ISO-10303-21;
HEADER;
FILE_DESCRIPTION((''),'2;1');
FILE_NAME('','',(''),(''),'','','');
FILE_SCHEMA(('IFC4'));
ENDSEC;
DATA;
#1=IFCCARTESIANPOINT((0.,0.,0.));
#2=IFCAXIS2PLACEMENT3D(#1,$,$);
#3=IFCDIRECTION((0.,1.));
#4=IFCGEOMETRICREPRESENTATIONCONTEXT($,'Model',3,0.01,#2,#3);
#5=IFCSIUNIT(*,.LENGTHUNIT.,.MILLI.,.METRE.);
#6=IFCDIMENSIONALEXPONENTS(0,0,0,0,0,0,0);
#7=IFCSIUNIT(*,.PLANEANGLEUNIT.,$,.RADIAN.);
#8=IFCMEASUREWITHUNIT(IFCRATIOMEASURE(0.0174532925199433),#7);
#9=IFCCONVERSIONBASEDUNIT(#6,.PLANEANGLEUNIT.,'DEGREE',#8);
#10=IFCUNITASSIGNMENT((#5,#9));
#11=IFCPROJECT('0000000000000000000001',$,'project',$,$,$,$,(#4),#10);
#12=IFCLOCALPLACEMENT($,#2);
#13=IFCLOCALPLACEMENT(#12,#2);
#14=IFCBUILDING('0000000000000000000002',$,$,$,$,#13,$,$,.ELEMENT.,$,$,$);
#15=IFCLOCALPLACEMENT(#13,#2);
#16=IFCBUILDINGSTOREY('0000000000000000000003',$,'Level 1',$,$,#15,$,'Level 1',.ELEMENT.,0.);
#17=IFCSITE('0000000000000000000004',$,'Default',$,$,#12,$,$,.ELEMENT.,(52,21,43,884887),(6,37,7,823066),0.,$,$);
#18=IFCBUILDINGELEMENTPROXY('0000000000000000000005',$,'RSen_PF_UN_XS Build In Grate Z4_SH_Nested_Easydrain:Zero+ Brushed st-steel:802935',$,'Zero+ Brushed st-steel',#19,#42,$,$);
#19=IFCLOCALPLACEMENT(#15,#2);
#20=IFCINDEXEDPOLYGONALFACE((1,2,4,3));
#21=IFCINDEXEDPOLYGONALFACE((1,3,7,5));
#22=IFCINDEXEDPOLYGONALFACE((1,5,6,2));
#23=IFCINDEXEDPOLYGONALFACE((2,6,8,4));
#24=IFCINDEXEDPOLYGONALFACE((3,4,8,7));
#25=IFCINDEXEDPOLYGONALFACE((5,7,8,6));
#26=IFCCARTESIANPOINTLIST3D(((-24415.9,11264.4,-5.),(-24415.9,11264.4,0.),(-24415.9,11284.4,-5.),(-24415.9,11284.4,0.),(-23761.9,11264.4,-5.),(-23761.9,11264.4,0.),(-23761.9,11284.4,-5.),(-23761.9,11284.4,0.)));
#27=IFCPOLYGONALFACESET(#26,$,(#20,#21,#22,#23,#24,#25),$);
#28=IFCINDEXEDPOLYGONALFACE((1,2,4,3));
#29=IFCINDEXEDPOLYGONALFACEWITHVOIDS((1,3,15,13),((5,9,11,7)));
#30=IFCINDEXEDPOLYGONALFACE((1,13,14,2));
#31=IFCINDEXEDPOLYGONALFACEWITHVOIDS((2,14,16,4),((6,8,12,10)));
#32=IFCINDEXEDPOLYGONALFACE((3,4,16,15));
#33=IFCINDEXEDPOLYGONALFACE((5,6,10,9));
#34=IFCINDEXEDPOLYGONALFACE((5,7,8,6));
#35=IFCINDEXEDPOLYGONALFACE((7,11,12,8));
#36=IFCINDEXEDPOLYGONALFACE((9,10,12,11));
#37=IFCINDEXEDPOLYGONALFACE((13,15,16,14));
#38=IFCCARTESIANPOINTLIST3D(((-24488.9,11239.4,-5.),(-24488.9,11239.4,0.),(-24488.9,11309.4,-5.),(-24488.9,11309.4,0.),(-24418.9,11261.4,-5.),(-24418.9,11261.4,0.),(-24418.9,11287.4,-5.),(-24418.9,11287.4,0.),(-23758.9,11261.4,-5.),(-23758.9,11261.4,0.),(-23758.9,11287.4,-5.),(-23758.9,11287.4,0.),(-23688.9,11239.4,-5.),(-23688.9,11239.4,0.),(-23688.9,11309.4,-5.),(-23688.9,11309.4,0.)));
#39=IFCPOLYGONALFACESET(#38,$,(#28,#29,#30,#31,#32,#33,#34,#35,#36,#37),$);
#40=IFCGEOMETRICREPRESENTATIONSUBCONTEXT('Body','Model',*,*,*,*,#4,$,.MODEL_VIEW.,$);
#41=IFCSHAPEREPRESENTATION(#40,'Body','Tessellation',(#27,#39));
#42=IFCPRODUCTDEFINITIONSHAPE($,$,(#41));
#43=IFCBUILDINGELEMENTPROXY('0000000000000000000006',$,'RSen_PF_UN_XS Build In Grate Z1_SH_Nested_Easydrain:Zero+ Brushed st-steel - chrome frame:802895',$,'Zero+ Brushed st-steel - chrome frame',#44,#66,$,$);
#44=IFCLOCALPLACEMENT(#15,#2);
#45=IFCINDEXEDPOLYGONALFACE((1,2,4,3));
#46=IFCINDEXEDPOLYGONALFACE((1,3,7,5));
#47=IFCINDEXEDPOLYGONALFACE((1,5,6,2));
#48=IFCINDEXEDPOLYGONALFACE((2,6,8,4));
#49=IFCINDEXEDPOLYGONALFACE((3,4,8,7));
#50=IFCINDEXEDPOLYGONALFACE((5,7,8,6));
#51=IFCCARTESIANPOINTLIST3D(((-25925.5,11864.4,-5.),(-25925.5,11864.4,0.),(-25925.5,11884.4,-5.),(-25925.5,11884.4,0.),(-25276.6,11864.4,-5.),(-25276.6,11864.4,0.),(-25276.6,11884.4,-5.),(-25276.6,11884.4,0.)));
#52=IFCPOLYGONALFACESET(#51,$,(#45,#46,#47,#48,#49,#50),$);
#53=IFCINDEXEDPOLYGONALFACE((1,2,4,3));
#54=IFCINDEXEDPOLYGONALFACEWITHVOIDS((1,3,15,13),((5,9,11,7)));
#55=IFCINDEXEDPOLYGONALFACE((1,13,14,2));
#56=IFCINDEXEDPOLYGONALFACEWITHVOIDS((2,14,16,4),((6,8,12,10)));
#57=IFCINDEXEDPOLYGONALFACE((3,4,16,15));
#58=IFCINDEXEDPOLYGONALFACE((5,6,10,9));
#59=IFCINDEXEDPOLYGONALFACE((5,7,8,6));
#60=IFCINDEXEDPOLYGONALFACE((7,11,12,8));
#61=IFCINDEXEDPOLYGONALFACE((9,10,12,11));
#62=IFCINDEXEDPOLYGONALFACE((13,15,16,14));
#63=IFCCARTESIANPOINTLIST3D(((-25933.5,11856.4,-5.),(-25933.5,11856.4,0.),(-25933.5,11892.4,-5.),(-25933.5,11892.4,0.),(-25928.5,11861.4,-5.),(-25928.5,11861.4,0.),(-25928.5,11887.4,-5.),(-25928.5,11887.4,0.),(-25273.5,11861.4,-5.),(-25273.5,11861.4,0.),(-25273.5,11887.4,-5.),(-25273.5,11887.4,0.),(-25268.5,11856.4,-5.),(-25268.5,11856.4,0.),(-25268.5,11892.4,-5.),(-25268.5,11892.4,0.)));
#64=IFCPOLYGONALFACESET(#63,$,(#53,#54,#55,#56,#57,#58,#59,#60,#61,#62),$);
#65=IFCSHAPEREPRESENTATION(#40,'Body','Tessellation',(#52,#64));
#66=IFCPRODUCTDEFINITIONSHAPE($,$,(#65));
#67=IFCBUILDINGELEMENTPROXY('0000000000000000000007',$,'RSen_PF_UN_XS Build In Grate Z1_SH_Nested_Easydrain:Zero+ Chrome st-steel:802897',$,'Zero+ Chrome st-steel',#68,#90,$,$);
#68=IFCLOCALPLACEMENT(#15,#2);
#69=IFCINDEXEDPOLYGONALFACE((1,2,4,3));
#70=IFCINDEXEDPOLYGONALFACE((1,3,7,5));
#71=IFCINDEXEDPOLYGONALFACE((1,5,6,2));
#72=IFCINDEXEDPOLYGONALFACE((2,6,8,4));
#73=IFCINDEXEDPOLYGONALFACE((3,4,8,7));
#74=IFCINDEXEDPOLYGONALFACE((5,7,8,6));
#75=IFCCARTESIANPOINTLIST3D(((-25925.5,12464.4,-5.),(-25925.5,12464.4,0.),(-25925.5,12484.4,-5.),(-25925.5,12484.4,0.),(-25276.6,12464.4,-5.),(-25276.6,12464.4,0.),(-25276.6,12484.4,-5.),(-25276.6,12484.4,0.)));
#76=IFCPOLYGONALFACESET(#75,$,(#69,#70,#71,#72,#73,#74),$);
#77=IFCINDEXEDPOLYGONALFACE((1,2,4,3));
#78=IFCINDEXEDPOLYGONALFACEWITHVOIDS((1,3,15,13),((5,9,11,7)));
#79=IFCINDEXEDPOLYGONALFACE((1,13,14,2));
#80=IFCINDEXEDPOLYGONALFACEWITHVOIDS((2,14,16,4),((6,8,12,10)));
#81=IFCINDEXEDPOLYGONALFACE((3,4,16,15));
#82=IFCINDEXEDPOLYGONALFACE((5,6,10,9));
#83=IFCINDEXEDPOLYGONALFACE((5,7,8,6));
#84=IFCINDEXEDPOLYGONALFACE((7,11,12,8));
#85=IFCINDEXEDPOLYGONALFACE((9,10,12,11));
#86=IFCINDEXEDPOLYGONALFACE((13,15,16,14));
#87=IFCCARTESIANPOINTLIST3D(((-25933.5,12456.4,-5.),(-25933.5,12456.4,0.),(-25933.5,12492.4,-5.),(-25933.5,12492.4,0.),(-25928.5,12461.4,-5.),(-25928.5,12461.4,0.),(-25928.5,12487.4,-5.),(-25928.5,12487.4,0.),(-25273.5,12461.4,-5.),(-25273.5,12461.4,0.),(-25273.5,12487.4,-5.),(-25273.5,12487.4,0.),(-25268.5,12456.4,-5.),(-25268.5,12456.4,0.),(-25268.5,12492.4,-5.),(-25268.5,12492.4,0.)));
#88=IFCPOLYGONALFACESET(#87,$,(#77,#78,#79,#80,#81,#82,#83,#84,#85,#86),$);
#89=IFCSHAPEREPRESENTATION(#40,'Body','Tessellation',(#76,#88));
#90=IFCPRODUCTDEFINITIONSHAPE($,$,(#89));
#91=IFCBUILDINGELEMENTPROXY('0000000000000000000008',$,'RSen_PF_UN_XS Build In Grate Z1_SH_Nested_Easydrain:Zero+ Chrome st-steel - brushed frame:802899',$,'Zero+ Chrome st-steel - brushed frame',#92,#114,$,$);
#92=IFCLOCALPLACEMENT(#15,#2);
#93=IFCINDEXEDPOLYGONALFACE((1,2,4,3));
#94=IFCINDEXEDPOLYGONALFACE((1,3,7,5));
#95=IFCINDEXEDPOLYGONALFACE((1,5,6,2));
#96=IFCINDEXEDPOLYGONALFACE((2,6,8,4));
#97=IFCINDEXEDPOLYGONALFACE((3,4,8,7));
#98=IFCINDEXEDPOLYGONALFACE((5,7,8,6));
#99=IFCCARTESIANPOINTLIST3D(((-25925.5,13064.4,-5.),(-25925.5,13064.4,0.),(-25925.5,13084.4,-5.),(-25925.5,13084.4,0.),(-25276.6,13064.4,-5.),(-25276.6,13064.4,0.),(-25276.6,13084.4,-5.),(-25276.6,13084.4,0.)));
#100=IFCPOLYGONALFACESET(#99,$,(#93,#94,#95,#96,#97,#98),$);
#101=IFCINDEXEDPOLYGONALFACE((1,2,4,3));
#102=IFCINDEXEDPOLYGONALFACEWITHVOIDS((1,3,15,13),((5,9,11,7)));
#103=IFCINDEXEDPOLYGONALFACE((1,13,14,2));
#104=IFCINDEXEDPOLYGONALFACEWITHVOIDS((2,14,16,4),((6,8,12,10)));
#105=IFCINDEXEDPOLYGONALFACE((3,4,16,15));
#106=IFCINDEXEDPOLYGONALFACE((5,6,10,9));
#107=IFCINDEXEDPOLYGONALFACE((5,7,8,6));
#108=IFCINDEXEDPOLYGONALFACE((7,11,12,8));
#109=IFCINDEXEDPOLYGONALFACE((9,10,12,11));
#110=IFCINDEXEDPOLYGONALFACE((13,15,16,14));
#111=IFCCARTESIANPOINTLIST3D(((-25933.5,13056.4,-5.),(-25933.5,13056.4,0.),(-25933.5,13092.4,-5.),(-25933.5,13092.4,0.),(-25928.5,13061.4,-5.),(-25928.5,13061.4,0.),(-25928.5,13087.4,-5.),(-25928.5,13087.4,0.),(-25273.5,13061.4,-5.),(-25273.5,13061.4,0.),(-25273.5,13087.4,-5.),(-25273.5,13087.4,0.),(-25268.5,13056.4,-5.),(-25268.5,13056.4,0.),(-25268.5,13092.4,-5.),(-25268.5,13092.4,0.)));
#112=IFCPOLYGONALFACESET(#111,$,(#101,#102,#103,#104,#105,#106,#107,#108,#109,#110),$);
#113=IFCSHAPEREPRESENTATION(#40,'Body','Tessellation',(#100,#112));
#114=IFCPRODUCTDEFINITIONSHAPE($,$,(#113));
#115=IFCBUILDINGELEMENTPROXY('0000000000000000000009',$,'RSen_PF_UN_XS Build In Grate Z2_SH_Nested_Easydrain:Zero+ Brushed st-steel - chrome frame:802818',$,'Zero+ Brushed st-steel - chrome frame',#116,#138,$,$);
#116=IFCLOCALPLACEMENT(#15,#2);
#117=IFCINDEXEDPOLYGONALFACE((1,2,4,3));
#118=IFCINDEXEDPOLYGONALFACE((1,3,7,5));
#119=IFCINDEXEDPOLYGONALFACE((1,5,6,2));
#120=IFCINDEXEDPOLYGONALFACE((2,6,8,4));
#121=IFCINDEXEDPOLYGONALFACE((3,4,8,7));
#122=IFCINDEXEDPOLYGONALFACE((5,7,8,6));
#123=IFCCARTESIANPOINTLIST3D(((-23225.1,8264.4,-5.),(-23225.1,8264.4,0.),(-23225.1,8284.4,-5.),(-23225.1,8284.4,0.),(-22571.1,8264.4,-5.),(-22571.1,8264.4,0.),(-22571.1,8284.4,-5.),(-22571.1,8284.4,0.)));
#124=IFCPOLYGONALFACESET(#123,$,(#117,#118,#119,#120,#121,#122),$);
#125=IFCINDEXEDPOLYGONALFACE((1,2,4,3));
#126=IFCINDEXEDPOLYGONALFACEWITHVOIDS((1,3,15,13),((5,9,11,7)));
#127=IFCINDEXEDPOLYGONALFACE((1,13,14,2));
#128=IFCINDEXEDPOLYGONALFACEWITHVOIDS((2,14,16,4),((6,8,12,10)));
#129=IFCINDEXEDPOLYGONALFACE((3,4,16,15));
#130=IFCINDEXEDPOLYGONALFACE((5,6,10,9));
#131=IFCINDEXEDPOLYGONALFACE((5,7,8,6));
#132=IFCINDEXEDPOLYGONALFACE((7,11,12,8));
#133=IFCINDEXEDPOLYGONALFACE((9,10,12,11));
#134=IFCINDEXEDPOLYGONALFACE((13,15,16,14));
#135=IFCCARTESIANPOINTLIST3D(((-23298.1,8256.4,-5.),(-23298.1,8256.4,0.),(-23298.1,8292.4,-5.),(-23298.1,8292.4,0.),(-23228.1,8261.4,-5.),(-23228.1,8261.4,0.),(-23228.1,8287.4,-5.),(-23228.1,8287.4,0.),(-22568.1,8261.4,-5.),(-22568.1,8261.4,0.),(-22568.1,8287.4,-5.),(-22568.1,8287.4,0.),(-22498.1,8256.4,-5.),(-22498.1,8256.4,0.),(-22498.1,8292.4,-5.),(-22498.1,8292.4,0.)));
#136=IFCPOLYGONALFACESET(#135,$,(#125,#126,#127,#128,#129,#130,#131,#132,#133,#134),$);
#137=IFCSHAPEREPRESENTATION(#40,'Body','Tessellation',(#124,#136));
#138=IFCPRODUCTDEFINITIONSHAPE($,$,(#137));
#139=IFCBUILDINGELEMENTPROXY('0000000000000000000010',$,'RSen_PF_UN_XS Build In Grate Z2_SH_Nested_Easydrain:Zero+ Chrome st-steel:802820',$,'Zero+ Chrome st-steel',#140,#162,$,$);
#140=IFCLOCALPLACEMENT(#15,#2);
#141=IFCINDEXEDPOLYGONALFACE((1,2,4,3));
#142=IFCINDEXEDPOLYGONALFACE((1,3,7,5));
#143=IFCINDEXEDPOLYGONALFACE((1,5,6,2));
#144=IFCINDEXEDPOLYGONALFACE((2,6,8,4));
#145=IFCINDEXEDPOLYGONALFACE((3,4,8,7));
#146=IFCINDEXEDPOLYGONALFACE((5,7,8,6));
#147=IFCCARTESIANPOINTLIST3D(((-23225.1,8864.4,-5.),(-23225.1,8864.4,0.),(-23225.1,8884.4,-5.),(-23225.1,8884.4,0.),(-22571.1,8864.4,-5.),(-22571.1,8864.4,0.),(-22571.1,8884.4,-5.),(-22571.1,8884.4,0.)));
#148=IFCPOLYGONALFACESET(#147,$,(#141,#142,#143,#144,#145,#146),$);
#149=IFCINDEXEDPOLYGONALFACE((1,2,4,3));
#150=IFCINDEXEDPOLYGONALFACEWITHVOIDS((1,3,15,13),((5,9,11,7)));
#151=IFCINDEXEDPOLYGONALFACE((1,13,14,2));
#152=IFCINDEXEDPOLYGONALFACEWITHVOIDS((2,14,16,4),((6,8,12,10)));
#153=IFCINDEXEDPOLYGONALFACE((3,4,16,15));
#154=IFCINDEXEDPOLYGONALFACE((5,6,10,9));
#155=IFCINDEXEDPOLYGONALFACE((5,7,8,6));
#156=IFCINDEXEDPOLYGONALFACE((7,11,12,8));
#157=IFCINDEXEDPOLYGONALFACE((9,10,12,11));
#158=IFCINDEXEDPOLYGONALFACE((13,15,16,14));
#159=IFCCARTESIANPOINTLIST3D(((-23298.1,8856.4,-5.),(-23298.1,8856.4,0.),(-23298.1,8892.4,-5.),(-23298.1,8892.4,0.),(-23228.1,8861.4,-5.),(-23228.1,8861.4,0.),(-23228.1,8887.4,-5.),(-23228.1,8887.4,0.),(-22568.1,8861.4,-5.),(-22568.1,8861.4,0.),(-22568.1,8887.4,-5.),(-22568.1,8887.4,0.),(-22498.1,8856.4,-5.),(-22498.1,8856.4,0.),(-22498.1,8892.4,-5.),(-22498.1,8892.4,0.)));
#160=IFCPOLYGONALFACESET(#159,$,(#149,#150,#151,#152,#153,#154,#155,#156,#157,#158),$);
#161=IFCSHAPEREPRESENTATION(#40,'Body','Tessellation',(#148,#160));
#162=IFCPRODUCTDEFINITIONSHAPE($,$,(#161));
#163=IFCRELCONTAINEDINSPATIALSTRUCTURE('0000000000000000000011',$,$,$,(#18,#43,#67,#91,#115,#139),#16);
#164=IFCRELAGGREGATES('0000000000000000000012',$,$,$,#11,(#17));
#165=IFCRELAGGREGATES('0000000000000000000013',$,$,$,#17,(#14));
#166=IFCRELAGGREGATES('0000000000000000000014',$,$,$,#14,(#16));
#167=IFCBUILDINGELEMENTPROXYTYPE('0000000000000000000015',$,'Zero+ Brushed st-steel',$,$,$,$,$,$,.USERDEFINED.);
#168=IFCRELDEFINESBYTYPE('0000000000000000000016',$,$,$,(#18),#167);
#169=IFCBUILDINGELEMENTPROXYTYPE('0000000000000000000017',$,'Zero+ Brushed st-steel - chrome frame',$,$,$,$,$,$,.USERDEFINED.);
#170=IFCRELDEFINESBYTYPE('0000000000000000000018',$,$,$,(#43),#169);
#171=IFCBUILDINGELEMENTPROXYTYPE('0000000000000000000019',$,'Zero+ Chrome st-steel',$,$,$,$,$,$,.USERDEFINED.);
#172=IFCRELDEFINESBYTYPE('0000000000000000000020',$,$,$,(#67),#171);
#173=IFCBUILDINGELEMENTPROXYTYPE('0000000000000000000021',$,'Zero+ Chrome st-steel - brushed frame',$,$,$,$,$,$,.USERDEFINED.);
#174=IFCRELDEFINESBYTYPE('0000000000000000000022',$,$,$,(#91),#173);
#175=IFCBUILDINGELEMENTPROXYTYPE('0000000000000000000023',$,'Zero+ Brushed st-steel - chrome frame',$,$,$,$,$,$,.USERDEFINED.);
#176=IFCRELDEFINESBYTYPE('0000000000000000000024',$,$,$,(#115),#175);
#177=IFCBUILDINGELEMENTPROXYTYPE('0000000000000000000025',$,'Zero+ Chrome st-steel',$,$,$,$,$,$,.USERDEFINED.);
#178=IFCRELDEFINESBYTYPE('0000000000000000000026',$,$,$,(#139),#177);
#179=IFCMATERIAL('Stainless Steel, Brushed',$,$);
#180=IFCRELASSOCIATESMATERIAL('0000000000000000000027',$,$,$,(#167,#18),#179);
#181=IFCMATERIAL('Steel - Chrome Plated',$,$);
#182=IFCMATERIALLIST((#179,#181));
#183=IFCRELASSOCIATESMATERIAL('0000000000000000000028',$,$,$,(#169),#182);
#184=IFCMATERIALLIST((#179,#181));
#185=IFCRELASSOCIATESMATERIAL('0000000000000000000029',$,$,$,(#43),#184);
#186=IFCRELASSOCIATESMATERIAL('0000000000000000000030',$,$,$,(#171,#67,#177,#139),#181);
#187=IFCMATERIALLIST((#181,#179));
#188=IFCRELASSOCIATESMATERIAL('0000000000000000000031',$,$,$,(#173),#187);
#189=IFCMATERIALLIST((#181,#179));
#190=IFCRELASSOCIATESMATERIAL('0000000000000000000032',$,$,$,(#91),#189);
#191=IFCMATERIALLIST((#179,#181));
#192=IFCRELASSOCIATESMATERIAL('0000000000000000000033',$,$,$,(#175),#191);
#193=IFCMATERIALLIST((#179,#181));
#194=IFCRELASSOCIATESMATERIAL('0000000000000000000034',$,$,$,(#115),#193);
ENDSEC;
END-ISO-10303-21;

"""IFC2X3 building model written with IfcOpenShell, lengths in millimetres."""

from ifc_helpers import new_model, entity, si_unit, converted_unit, direction, frame, origin, origin_2d_with_axis, place, context, subcontext, project, spatial, polyline, rectangle, outline, extrude, source, transform, mapped, material, material_list, type_object, type_shapes, element, save


model = new_model("IFC2X3")

# Units and contexts
model_context = context("Model", 3, precision=0.01, world=origin(), true_north=direction((0.0, 1.0)))
body_context = subcontext(model_context, "Body", "Model", "MODEL_VIEW")
ifc_project = project(units=[si_unit("LENGTHUNIT", "METRE", prefix="MILLI"), converted_unit("PLANEANGLEUNIT", "DEGREE", entity("IfcRatioMeasure", 0.0174532925199433), si_unit("PLANEANGLEUNIT", "RADIAN"), dimensions=[0, 0, 0, 0, 0, 0, 0])], contexts=[model_context])

# Site, building, storey
site_placement = place(None, origin())
site = spatial("IfcSite", under=ifc_project, at=site_placement, Name="Default", CompositionType="ELEMENT", RefLatitude=(52, 21, 43, 884887), RefLongitude=(6, 37, 7, 823066), RefElevation=0.0)
building_placement = place(site_placement, origin())
building = spatial("IfcBuilding", under=site, at=building_placement, CompositionType="ELEMENT")
storey_placement = place(building_placement, origin())
storey = spatial("IfcBuildingStorey", under=building, at=storey_placement, Name="Level 1", LongName="Level 1", CompositionType="ELEMENT", Elevation=0.0)

# Shared definitions
ifc_material_1 = material(Name="Stainless Steel, Brushed")

# Building element proxies
building_element_proxy_type_1 = type_object("IfcBuildingElementProxyType", Name="Zero+ Brushed st-steel", PredefinedType="USERDEFINED", material=ifc_material_1)
shared_shape_1 = source(origin(), body_context, "Body", "SweptSolid", [
    extrude(rectangle(XDim=654.0, YDim=20.0, at=origin_2d_with_axis()), frame((0.0, 0.0, 0.0), z_axis=(0.0, 0.0, 1.0), x_axis=(-1.0, 0.0, 0.0)), (0.0, 0.0, 1.0), 5.0),
    extrude(outline(polyline([(-400.0, -35.0), (400.0, -35.0), (400.0, 35.0), (-400.0, 35.0), (-400.0, -35.0)]), holes=[polyline([(-330.0, -13.0), (-330.0, 13.0), (330.0, 13.0), (330.0, -13.0), (-330.0, -13.0)])]), frame((0.0, 0.0, 0.0), z_axis=(0.0, 0.0, 1.0), x_axis=(-1.0, 0.0, 0.0)), (0.0, 0.0, 1.0), 5.0),
])
type_shapes(building_element_proxy_type_1, [shared_shape_1])
for number, where, name in (
    (1, (-24088.9, 11274.4, -5.0), "RSen_PF_UN_XS Build In Grate Z4_SH_Nested_Easydrain:Zero+ Brushed st-steel:802935"),
):
    element("IfcBuildingElementProxy", number, at=place(storey_placement, frame(where)), inside=storey, type_object=building_element_proxy_type_1, material=ifc_material_1, Name=name, ObjectType="Zero+ Brushed st-steel", context=body_context, shape_type="MappedRepresentation", body=[
        mapped(shared_shape_1, transform((0.0, 0.0, 0.0), scale=1.0)),
    ])
ifc_material_2 = material(Name="Steel - Chrome Plated")
ifc_material_list_1 = material_list([ifc_material_1, ifc_material_2])
ifc_material_list_2 = material_list([ifc_material_1, ifc_material_2])
building_element_proxy_type_2 = type_object("IfcBuildingElementProxyType", Name="Zero+ Brushed st-steel - chrome frame", PredefinedType="USERDEFINED", material=ifc_material_list_2)
shared_shape_2 = source(origin(), body_context, "Body", "SweptSolid", [
    extrude(rectangle(XDim=649.0, YDim=20.0, at=origin_2d_with_axis()), frame((0.0, 0.0, 0.0), z_axis=(0.0, 0.0, 1.0), x_axis=(-1.0, 0.0, 0.0)), (0.0, 0.0, 1.0), 5.0),
    extrude(outline(polyline([(-332.5, -18.0), (332.5, -18.0), (332.5, 18.0), (-332.5, 18.0), (-332.5, -18.0)]), holes=[polyline([(-327.5, -13.0), (-327.5, 13.0), (327.5, 13.0), (327.5, -13.0), (-327.5, -13.0)])]), frame((0.0, 0.0, 0.0), z_axis=(0.0, 0.0, 1.0), x_axis=(-1.0, 0.0, 0.0)), (0.0, 0.0, 1.0), 5.0),
])
type_shapes(building_element_proxy_type_2, [shared_shape_2])
proxy_1_placement = place(storey_placement, frame((-25601.0, 11874.4, -5.0)))
element("IfcBuildingElementProxy", 2, at=proxy_1_placement, inside=storey, type_object=building_element_proxy_type_2, material=ifc_material_list_1, Name="RSen_PF_UN_XS Build In Grate Z1_SH_Nested_Easydrain:Zero+ Brushed st-steel - chrome frame:802895", ObjectType="Zero+ Brushed st-steel - chrome frame", context=body_context, shape_type="MappedRepresentation", body=[
    mapped(shared_shape_2, transform((0.0, 0.0, 0.0), scale=1.0)),
])
building_element_proxy_type_3 = type_object("IfcBuildingElementProxyType", Name="Zero+ Chrome st-steel", PredefinedType="USERDEFINED", material=ifc_material_2)
shared_shape_3 = source(origin(), body_context, "Body", "SweptSolid", [
    extrude(rectangle(XDim=649.0, YDim=20.0, at=origin_2d_with_axis()), frame((0.0, 0.0, 0.0), z_axis=(0.0, 0.0, 1.0), x_axis=(-1.0, 0.0, 0.0)), (0.0, 0.0, 1.0), 5.0),
    extrude(outline(polyline([(-332.5, -18.0), (332.5, -18.0), (332.5, 18.0), (-332.5, 18.0), (-332.5, -18.0)]), holes=[polyline([(-327.5, -13.0), (-327.5, 13.0), (327.5, 13.0), (327.5, -13.0), (-327.5, -13.0)])]), frame((0.0, 0.0, 0.0), z_axis=(0.0, 0.0, 1.0), x_axis=(-1.0, 0.0, 0.0)), (0.0, 0.0, 1.0), 5.0),
])
type_shapes(building_element_proxy_type_3, [shared_shape_3])
proxy_2_placement = place(storey_placement, frame((-25601.0, 12474.4, -5.0)))
element("IfcBuildingElementProxy", 3, at=proxy_2_placement, inside=storey, type_object=building_element_proxy_type_3, material=ifc_material_2, Name="RSen_PF_UN_XS Build In Grate Z1_SH_Nested_Easydrain:Zero+ Chrome st-steel:802897", ObjectType="Zero+ Chrome st-steel", context=body_context, shape_type="MappedRepresentation", body=[
    mapped(shared_shape_3, transform((0.0, 0.0, 0.0), scale=1.0)),
])
ifc_material_list_3 = material_list([ifc_material_2, ifc_material_1])
ifc_material_list_4 = material_list([ifc_material_2, ifc_material_1])
building_element_proxy_type_4 = type_object("IfcBuildingElementProxyType", Name="Zero+ Chrome st-steel - brushed frame", PredefinedType="USERDEFINED", material=ifc_material_list_4)
shared_shape_4 = source(origin(), body_context, "Body", "SweptSolid", [
    extrude(rectangle(XDim=649.0, YDim=20.0, at=origin_2d_with_axis()), frame((0.0, 0.0, 0.0), z_axis=(0.0, 0.0, 1.0), x_axis=(-1.0, 0.0, 0.0)), (0.0, 0.0, 1.0), 5.0),
    extrude(outline(polyline([(-332.5, -18.0), (332.5, -18.0), (332.5, 18.0), (-332.5, 18.0), (-332.5, -18.0)]), holes=[polyline([(-327.5, -13.0), (-327.5, 13.0), (327.5, 13.0), (327.5, -13.0), (-327.5, -13.0)])]), frame((0.0, 0.0, 0.0), z_axis=(0.0, 0.0, 1.0), x_axis=(-1.0, 0.0, 0.0)), (0.0, 0.0, 1.0), 5.0),
])
type_shapes(building_element_proxy_type_4, [shared_shape_4])
proxy_3_placement = place(storey_placement, frame((-25601.0, 13074.4, -5.0)))
element("IfcBuildingElementProxy", 4, at=proxy_3_placement, inside=storey, type_object=building_element_proxy_type_4, material=ifc_material_list_3, Name="RSen_PF_UN_XS Build In Grate Z1_SH_Nested_Easydrain:Zero+ Chrome st-steel - brushed frame:802899", ObjectType="Zero+ Chrome st-steel - brushed frame", context=body_context, shape_type="MappedRepresentation", body=[
    mapped(shared_shape_4, transform((0.0, 0.0, 0.0), scale=1.0)),
])
ifc_material_list_5 = material_list([ifc_material_1, ifc_material_2])
ifc_material_list_6 = material_list([ifc_material_1, ifc_material_2])
building_element_proxy_type_5 = type_object("IfcBuildingElementProxyType", Name="Zero+ Brushed st-steel - chrome frame", PredefinedType="USERDEFINED", material=ifc_material_list_6)
shared_shape_5 = source(origin(), body_context, "Body", "SweptSolid", [
    extrude(rectangle(XDim=654.0, YDim=20.0, at=origin_2d_with_axis()), frame((0.0, 0.0, 0.0), z_axis=(0.0, 0.0, 1.0), x_axis=(-1.0, 0.0, 0.0)), (0.0, 0.0, 1.0), 5.0),
    extrude(outline(polyline([(-400.0, -18.0), (400.0, -18.0), (400.0, 18.0), (-400.0, 18.0), (-400.0, -18.0)]), holes=[polyline([(-330.0, -13.0), (-330.0, 13.0), (330.0, 13.0), (330.0, -13.0), (-330.0, -13.0)])]), frame((0.0, 0.0, 0.0), z_axis=(0.0, 0.0, 1.0), x_axis=(-1.0, 0.0, 0.0)), (0.0, 0.0, 1.0), 5.0),
])
type_shapes(building_element_proxy_type_5, [shared_shape_5])
proxy_4_placement = place(storey_placement, frame((-22898.1, 8274.4, -5.0)))
element("IfcBuildingElementProxy", 5, at=proxy_4_placement, inside=storey, type_object=building_element_proxy_type_5, material=ifc_material_list_5, Name="RSen_PF_UN_XS Build In Grate Z2_SH_Nested_Easydrain:Zero+ Brushed st-steel - chrome frame:802818", ObjectType="Zero+ Brushed st-steel - chrome frame", context=body_context, shape_type="MappedRepresentation", body=[
    mapped(shared_shape_5, transform((0.0, 0.0, 0.0), scale=1.0)),
])
building_element_proxy_type_6 = type_object("IfcBuildingElementProxyType", Name="Zero+ Chrome st-steel", PredefinedType="USERDEFINED", material=ifc_material_2)
shared_shape_6 = source(origin(), body_context, "Body", "SweptSolid", [
    extrude(rectangle(XDim=654.0, YDim=20.0, at=origin_2d_with_axis()), frame((0.0, 0.0, 0.0), z_axis=(0.0, 0.0, 1.0), x_axis=(-1.0, 0.0, 0.0)), (0.0, 0.0, 1.0), 5.0),
    extrude(outline(polyline([(-400.0, -18.0), (400.0, -18.0), (400.0, 18.0), (-400.0, 18.0), (-400.0, -18.0)]), holes=[polyline([(-330.0, -13.0), (-330.0, 13.0), (330.0, 13.0), (330.0, -13.0), (-330.0, -13.0)])]), frame((0.0, 0.0, 0.0), z_axis=(0.0, 0.0, 1.0), x_axis=(-1.0, 0.0, 0.0)), (0.0, 0.0, 1.0), 5.0),
])
type_shapes(building_element_proxy_type_6, [shared_shape_6])
proxy_5_placement = place(storey_placement, frame((-22898.1, 8874.4, -5.0)))
element("IfcBuildingElementProxy", 6, at=proxy_5_placement, inside=storey, type_object=building_element_proxy_type_6, material=ifc_material_2, Name="RSen_PF_UN_XS Build In Grate Z2_SH_Nested_Easydrain:Zero+ Chrome st-steel:802820", ObjectType="Zero+ Chrome st-steel", context=body_context, shape_type="MappedRepresentation", body=[
    mapped(shared_shape_6, transform((0.0, 0.0, 0.0), scale=1.0)),
])

save(model, "model.ifc")
